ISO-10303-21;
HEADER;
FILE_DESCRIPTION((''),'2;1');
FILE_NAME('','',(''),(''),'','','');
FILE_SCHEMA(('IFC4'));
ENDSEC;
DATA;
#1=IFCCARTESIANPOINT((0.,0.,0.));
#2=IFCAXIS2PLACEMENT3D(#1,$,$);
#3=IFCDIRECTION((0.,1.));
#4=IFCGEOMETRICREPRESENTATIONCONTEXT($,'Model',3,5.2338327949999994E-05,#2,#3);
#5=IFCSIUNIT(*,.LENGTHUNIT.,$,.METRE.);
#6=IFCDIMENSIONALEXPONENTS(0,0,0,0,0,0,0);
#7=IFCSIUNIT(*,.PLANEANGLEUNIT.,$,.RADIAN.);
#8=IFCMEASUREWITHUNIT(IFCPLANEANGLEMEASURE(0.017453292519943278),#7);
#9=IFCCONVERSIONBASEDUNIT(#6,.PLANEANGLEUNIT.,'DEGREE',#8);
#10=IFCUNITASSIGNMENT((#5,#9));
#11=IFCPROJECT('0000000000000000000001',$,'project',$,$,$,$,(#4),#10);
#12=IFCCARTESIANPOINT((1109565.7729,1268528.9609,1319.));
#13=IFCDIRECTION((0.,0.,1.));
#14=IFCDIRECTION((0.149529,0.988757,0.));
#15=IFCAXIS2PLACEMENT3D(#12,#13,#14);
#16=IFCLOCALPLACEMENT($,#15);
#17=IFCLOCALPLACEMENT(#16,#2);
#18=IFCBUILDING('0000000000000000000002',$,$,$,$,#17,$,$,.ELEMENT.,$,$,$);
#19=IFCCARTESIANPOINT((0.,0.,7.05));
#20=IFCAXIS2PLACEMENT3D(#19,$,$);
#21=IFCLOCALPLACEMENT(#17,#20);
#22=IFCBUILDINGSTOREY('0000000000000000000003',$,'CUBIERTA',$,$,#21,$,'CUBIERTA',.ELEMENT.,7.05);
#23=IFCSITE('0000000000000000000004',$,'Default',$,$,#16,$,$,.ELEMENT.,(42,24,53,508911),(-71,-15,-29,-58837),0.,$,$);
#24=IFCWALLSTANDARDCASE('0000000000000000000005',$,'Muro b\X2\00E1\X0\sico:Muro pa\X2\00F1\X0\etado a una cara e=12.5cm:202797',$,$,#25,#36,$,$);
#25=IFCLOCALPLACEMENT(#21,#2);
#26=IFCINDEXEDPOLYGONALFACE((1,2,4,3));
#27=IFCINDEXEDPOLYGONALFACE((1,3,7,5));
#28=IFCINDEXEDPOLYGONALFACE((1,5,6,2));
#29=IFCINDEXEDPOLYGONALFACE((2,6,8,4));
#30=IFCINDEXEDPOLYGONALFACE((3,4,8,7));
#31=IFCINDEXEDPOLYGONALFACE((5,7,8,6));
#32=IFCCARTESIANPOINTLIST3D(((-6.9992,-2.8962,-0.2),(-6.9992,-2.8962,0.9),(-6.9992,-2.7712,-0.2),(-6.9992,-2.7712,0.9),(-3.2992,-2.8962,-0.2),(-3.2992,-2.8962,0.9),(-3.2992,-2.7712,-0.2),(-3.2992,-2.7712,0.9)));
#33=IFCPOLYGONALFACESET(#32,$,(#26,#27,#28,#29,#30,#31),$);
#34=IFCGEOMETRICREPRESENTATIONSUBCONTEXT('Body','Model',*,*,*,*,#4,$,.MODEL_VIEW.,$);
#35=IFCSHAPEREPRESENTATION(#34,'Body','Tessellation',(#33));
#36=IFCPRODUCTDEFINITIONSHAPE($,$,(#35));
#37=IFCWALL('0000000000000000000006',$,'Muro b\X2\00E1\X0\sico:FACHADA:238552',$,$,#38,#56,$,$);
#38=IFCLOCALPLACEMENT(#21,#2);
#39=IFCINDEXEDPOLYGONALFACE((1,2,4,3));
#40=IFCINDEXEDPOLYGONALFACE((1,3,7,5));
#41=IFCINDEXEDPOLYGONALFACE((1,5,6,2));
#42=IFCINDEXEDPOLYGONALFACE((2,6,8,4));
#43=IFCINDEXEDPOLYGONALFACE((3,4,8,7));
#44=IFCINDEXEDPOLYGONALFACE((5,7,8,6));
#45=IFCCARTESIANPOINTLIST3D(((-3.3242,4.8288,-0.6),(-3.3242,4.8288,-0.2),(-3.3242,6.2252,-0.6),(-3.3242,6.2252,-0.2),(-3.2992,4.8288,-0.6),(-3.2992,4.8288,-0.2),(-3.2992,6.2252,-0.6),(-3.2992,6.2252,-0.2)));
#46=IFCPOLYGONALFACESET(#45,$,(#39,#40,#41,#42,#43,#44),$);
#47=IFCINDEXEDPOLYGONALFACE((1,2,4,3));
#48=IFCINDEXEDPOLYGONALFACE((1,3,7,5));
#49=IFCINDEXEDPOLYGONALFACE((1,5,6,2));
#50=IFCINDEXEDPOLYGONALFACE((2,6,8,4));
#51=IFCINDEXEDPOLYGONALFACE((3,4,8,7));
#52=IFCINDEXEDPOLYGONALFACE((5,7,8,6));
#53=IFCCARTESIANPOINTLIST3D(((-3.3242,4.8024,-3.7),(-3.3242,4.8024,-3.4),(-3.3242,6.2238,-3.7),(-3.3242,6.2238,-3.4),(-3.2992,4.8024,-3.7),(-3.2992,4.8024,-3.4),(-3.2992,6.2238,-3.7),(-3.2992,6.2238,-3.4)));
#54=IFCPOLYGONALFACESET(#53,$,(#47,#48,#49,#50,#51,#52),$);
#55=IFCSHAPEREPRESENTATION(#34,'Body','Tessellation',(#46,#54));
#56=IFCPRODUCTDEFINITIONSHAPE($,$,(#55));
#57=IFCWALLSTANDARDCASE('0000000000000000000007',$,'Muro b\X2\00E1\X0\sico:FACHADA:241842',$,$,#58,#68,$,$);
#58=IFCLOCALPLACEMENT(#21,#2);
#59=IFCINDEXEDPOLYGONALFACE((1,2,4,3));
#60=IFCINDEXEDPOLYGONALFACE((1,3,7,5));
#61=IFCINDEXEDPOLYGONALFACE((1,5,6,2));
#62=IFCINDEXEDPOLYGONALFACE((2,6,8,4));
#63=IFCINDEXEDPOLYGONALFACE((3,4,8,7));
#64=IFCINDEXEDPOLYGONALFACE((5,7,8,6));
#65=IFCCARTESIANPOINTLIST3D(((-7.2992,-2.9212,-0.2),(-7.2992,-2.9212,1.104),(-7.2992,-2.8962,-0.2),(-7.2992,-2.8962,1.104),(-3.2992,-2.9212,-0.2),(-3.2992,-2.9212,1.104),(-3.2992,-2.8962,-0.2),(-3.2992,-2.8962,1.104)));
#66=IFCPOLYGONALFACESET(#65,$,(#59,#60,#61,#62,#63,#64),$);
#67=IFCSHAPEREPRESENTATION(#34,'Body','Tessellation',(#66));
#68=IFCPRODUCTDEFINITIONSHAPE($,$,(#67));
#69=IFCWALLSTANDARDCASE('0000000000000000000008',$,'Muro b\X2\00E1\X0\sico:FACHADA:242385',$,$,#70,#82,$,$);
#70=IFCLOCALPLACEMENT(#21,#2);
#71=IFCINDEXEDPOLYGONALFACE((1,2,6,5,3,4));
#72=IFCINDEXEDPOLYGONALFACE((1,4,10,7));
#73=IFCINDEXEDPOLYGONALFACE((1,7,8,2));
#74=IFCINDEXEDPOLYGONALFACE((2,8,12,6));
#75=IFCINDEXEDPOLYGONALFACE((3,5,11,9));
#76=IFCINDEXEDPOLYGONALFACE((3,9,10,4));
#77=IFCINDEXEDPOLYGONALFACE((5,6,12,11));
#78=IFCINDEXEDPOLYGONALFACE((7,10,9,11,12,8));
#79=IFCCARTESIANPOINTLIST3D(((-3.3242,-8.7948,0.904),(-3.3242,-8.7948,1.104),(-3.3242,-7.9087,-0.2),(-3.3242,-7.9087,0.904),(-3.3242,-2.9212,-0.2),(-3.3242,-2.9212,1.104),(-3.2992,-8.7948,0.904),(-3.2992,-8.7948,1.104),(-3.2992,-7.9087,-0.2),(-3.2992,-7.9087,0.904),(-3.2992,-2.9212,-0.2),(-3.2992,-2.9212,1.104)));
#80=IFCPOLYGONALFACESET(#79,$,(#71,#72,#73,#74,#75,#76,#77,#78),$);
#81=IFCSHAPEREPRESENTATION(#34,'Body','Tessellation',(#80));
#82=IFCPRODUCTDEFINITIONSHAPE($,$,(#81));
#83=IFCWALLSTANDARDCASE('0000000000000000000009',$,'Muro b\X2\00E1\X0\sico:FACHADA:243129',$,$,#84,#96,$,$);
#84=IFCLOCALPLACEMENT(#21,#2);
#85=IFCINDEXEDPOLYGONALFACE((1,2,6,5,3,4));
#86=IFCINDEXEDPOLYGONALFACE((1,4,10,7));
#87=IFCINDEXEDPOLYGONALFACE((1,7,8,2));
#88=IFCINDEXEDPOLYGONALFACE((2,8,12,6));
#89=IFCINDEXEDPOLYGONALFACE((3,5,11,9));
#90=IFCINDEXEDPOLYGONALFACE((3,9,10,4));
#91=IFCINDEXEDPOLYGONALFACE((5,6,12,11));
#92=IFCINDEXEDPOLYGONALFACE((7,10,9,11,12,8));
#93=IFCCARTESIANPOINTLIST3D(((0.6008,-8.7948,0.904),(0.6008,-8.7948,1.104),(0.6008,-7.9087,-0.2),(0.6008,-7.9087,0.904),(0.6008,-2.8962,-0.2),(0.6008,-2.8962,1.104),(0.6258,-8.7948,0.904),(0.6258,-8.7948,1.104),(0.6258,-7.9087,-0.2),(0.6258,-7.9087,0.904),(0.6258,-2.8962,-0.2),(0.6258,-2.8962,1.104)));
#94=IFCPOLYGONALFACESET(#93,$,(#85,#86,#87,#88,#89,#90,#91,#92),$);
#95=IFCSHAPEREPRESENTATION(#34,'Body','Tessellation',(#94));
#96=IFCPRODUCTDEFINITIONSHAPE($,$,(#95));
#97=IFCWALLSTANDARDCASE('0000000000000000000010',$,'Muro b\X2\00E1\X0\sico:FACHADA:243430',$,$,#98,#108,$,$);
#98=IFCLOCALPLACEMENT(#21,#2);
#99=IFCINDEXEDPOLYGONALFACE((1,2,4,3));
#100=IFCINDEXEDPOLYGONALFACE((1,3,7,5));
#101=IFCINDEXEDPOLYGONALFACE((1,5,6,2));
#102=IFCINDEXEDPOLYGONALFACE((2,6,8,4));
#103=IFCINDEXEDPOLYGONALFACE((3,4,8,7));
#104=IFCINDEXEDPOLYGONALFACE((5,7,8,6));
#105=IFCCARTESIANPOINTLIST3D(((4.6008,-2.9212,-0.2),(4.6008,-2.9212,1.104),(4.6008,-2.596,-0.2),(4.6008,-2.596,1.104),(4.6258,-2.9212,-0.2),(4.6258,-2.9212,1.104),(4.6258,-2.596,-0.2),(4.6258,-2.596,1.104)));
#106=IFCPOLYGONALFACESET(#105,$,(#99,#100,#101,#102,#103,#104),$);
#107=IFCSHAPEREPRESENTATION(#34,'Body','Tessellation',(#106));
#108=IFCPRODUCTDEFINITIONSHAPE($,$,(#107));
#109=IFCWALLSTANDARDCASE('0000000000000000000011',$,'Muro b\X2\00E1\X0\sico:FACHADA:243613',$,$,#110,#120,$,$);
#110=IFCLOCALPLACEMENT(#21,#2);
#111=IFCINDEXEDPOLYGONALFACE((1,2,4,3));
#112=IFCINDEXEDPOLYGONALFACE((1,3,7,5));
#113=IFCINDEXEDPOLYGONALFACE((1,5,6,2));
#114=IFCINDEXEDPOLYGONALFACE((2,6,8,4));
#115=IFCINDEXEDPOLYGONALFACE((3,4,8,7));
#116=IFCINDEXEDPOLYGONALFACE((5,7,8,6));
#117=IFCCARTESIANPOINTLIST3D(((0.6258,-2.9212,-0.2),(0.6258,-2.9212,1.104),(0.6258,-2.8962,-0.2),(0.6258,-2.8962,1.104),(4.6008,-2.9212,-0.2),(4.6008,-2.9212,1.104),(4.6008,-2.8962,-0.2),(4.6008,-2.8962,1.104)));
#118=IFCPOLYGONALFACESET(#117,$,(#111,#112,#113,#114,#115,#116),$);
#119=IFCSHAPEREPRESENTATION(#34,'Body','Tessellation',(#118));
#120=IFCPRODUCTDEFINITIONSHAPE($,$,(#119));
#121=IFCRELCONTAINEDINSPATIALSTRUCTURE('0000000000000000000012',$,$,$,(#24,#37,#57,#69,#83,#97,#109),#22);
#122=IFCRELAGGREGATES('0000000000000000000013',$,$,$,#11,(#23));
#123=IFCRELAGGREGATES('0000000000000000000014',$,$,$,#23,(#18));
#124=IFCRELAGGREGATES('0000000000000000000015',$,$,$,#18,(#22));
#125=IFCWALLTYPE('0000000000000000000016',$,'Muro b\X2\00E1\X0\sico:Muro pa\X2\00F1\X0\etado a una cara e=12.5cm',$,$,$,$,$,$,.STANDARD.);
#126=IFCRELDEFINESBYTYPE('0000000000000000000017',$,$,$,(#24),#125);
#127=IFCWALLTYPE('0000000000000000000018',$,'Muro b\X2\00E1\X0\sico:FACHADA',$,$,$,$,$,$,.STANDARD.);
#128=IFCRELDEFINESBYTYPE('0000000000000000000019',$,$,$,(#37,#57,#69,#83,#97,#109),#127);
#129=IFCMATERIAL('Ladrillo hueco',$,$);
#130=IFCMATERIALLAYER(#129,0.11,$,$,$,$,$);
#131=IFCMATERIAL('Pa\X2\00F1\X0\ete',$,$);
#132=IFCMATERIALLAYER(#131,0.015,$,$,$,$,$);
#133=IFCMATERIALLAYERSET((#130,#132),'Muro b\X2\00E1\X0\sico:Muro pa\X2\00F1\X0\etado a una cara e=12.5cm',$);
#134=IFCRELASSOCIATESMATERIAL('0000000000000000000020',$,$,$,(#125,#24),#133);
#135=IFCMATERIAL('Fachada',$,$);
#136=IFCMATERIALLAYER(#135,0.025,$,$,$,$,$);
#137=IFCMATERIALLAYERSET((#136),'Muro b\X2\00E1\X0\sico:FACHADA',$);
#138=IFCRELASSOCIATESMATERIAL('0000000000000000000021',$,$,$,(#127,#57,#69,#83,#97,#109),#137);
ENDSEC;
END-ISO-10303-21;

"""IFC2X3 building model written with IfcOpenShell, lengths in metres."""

from ifc_helpers import new_model, entity, si_unit, converted_unit, direction, frame, frame_2d, origin, place, context, subcontext, project, spatial, rectangle, extrude, material, layer, layer_set, layer_usage, type_object, element, save


model = new_model("IFC2X3")

# Units and contexts
model_context = context("Model", 3, precision=5.2338327949999994e-05, world=origin(), true_north=direction((0.0, 1.0)))
body_context = subcontext(model_context, "Body", "Model", "MODEL_VIEW")
ifc_project = project(units=[si_unit("LENGTHUNIT", "METRE"), converted_unit("PLANEANGLEUNIT", "DEGREE", entity("IfcPlaneAngleMeasure", 0.017453292519943278), si_unit("PLANEANGLEUNIT", "RADIAN"), dimensions=[0, 0, 0, 0, 0, 0, 0])], contexts=[model_context])

# Site, building, storey
site_placement = place(None, frame((1109565.7729, 1268528.9609, 1319.0), z_axis=(0.0, 0.0, 1.0), x_axis=(0.149529, 0.988757, 0.0)))
site = spatial("IfcSite", under=ifc_project, at=site_placement, Name="Default", CompositionType="ELEMENT", RefLatitude=(42, 24, 53, 508911), RefLongitude=(-71, -15, -29, -58837), RefElevation=0.0)
building_placement = place(site_placement, origin())
building = spatial("IfcBuilding", under=site, at=building_placement, CompositionType="ELEMENT")
storey_placement = place(building_placement, frame((0.0, 0.0, 7.05)))
storey = spatial("IfcBuildingStorey", under=building, at=storey_placement, Name="CUBIERTA", LongName="CUBIERTA", CompositionType="ELEMENT", Elevation=7.05)

# Walls
ifc_material_1 = material(Name="Ladrillo hueco")
ifc_layer_1 = layer(ifc_material_1, 0.11)
ifc_material_2 = material(Name="Pañete")
ifc_layer_2 = layer(ifc_material_2, 0.015)
ifc_layer_set_1 = layer_set([ifc_layer_1, ifc_layer_2], Name="Muro básico:Muro pañetado a una cara e=12.5cm")
wall_type_1 = type_object("IfcWallType", Name="Muro básico:Muro pañetado a una cara e=12.5cm", PredefinedType="STANDARD", material=ifc_layer_set_1)
ifc_layer_usage_1 = layer_usage(ifc_layer_set_1, "AXIS2", "POSITIVE", -0.0625)
wall_1_placement = place(storey_placement, frame((-6.9992, -2.8337, -0.2)))
element("IfcWallStandardCase", 1, at=wall_1_placement, inside=storey, type_object=wall_type_1, material=ifc_layer_usage_1, Name="Muro básico:Muro pañetado a una cara e=12.5cm:202797", context=body_context, shape_type="SweptSolid", body=[
    extrude(rectangle(XDim=3.7, YDim=0.125, at=frame_2d((1.85, 0.0), x_axis=(-1.0, 0.0))), origin(), (0.0, 0.0, 1.0), 1.1),
])
ifc_material_3 = material(Name="Fachada")
ifc_layer_3 = layer(ifc_material_3, 0.025)
ifc_layer_set_2 = layer_set([ifc_layer_3], Name="Muro básico:FACHADA")
wall_type_2 = type_object("IfcWallType", Name="Muro básico:FACHADA", PredefinedType="STANDARD", material=ifc_layer_set_2)
wall_2_placement = place(storey_placement, frame((-3.3117, 6.2252, -3.7), z_axis=(0.0, 0.0, 1.0), x_axis=(0.0, -1.0, 0.0)))
element("IfcWall", 2, at=wall_2_placement, inside=storey, type_object=wall_type_2, Name="Muro básico:FACHADA:238552", context=body_context, shape_type="SweptSolid", body=[
    extrude(rectangle(XDim=0.025, YDim=1.3964, at=frame_2d((0.0, 0.0), x_axis=(1.0, 0.0))), frame((0.6982, 0.0, 3.1), z_axis=(0.0, 0.0, 1.0), x_axis=(0.0, 1.0, 0.0)), (0.0, 0.0, 1.0), 0.4),
    extrude(rectangle(XDim=0.025, YDim=1.4214, at=frame_2d((0.0, 0.0), x_axis=(1.0, 0.0))), frame((0.7121, 0.0, 0.0), z_axis=(0.0, 0.0, 1.0), x_axis=(0.0, 1.0, 0.0)), (0.0, 0.0, 1.0), 0.3),
])
ifc_layer_usage_2 = layer_usage(ifc_layer_set_2, "AXIS2", "POSITIVE", -0.0125)
wall_3_placement = place(storey_placement, frame((-7.2992, -2.9087, -0.2)))
element("IfcWallStandardCase", 3, at=wall_3_placement, inside=storey, type_object=wall_type_2, material=ifc_layer_usage_2, Name="Muro básico:FACHADA:241842", context=body_context, shape_type="SweptSolid", body=[
    extrude(rectangle(XDim=4.0, YDim=0.025, at=frame_2d((2.0, 0.0), x_axis=(-1.0, 0.0))), origin(), (0.0, 0.0, 1.0), 1.304),
])

# Walls, openings
ifc_layer_usage_3 = layer_usage(ifc_layer_set_2, "AXIS2", "POSITIVE", -0.0125)
wall_4_placement = place(storey_placement, frame((-3.3117, -2.9212, -0.2), z_axis=(0.0, 0.0, 1.0), x_axis=(0.0, -1.0, 0.0)))
wall_4 = element("IfcWallStandardCase", 4, at=wall_4_placement, inside=storey, type_object=wall_type_2, material=ifc_layer_usage_3, Name="Muro básico:FACHADA:242385", context=body_context, shape_type="SweptSolid", body=[
    extrude(rectangle(XDim=5.8736, YDim=0.025, at=frame_2d((2.9368, 0.0), x_axis=(-1.0, 0.0))), origin(), (0.0, 0.0, 1.0), 1.304),
])
opening_1_placement = place(wall_4_placement, origin())
element("IfcOpeningElement", 5, at=opening_1_placement, cuts=wall_4, ObjectType="Opening", context=body_context, shape_type="SweptSolid", body=[
    extrude(rectangle(XDim=1.104, YDim=0.8861, at=frame_2d((0.0, 0.0), x_axis=(0.0, 1.0))), frame((5.4305, 0.0125, 0.552), z_axis=(0.0, -1.0, 0.0), x_axis=(1.0, 0.0, 0.0)), (0.0, 0.0, 1.0), 0.025),
])
ifc_layer_usage_4 = layer_usage(ifc_layer_set_2, "AXIS2", "NEGATIVE", 0.0125)
wall_5_placement = place(storey_placement, frame((0.6133, -2.8962, -0.2), z_axis=(0.0, 0.0, 1.0), x_axis=(0.0, -1.0, 0.0)))
wall_5 = element("IfcWallStandardCase", 6, at=wall_5_placement, inside=storey, type_object=wall_type_2, material=ifc_layer_usage_4, Name="Muro básico:FACHADA:243129", context=body_context, shape_type="SweptSolid", body=[
    extrude(rectangle(XDim=5.8986, YDim=0.025, at=frame_2d((2.9493, 0.0), x_axis=(-1.0, 0.0))), origin(), (0.0, 0.0, 1.0), 1.304),
])
opening_2_placement = place(wall_5_placement, origin())
element("IfcOpeningElement", 7, at=opening_2_placement, cuts=wall_5, ObjectType="Opening", context=body_context, shape_type="SweptSolid", body=[
    extrude(rectangle(XDim=1.104, YDim=0.8861, at=frame_2d((0.0, 0.0), x_axis=(0.0, 1.0))), frame((5.4555, 0.0125, 0.552), z_axis=(0.0, -1.0, 0.0), x_axis=(1.0, 0.0, 0.0)), (0.0, 0.0, 1.0), 0.025),
])

# Walls
ifc_layer_usage_5 = layer_usage(ifc_layer_set_2, "AXIS2", "NEGATIVE", 0.0125)
wall_6_placement = place(storey_placement, frame((4.6133, -2.596, -0.2), z_axis=(0.0, 0.0, 1.0), x_axis=(0.0, -1.0, 0.0)))
element("IfcWallStandardCase", 8, at=wall_6_placement, inside=storey, type_object=wall_type_2, material=ifc_layer_usage_5, Name="Muro básico:FACHADA:243430", context=body_context, shape_type="SweptSolid", body=[
    extrude(rectangle(XDim=0.3252, YDim=0.025, at=frame_2d((0.1626, 0.0), x_axis=(-1.0, 0.0))), origin(), (0.0, 0.0, 1.0), 1.304),
])
ifc_layer_usage_6 = layer_usage(ifc_layer_set_2, "AXIS2", "NEGATIVE", 0.0125)
wall_7_placement = place(storey_placement, frame((4.6008, -2.9087, -0.2), z_axis=(0.0, 0.0, 1.0), x_axis=(-1.0, 0.0, 0.0)))
element("IfcWallStandardCase", 9, at=wall_7_placement, inside=storey, type_object=wall_type_2, material=ifc_layer_usage_6, Name="Muro básico:FACHADA:243613", context=body_context, shape_type="SweptSolid", body=[
    extrude(rectangle(XDim=3.975, YDim=0.025, at=frame_2d((1.9875, 0.0), x_axis=(-1.0, 0.0))), origin(), (0.0, 0.0, 1.0), 1.304),
])

save(model, "model.ifc")
